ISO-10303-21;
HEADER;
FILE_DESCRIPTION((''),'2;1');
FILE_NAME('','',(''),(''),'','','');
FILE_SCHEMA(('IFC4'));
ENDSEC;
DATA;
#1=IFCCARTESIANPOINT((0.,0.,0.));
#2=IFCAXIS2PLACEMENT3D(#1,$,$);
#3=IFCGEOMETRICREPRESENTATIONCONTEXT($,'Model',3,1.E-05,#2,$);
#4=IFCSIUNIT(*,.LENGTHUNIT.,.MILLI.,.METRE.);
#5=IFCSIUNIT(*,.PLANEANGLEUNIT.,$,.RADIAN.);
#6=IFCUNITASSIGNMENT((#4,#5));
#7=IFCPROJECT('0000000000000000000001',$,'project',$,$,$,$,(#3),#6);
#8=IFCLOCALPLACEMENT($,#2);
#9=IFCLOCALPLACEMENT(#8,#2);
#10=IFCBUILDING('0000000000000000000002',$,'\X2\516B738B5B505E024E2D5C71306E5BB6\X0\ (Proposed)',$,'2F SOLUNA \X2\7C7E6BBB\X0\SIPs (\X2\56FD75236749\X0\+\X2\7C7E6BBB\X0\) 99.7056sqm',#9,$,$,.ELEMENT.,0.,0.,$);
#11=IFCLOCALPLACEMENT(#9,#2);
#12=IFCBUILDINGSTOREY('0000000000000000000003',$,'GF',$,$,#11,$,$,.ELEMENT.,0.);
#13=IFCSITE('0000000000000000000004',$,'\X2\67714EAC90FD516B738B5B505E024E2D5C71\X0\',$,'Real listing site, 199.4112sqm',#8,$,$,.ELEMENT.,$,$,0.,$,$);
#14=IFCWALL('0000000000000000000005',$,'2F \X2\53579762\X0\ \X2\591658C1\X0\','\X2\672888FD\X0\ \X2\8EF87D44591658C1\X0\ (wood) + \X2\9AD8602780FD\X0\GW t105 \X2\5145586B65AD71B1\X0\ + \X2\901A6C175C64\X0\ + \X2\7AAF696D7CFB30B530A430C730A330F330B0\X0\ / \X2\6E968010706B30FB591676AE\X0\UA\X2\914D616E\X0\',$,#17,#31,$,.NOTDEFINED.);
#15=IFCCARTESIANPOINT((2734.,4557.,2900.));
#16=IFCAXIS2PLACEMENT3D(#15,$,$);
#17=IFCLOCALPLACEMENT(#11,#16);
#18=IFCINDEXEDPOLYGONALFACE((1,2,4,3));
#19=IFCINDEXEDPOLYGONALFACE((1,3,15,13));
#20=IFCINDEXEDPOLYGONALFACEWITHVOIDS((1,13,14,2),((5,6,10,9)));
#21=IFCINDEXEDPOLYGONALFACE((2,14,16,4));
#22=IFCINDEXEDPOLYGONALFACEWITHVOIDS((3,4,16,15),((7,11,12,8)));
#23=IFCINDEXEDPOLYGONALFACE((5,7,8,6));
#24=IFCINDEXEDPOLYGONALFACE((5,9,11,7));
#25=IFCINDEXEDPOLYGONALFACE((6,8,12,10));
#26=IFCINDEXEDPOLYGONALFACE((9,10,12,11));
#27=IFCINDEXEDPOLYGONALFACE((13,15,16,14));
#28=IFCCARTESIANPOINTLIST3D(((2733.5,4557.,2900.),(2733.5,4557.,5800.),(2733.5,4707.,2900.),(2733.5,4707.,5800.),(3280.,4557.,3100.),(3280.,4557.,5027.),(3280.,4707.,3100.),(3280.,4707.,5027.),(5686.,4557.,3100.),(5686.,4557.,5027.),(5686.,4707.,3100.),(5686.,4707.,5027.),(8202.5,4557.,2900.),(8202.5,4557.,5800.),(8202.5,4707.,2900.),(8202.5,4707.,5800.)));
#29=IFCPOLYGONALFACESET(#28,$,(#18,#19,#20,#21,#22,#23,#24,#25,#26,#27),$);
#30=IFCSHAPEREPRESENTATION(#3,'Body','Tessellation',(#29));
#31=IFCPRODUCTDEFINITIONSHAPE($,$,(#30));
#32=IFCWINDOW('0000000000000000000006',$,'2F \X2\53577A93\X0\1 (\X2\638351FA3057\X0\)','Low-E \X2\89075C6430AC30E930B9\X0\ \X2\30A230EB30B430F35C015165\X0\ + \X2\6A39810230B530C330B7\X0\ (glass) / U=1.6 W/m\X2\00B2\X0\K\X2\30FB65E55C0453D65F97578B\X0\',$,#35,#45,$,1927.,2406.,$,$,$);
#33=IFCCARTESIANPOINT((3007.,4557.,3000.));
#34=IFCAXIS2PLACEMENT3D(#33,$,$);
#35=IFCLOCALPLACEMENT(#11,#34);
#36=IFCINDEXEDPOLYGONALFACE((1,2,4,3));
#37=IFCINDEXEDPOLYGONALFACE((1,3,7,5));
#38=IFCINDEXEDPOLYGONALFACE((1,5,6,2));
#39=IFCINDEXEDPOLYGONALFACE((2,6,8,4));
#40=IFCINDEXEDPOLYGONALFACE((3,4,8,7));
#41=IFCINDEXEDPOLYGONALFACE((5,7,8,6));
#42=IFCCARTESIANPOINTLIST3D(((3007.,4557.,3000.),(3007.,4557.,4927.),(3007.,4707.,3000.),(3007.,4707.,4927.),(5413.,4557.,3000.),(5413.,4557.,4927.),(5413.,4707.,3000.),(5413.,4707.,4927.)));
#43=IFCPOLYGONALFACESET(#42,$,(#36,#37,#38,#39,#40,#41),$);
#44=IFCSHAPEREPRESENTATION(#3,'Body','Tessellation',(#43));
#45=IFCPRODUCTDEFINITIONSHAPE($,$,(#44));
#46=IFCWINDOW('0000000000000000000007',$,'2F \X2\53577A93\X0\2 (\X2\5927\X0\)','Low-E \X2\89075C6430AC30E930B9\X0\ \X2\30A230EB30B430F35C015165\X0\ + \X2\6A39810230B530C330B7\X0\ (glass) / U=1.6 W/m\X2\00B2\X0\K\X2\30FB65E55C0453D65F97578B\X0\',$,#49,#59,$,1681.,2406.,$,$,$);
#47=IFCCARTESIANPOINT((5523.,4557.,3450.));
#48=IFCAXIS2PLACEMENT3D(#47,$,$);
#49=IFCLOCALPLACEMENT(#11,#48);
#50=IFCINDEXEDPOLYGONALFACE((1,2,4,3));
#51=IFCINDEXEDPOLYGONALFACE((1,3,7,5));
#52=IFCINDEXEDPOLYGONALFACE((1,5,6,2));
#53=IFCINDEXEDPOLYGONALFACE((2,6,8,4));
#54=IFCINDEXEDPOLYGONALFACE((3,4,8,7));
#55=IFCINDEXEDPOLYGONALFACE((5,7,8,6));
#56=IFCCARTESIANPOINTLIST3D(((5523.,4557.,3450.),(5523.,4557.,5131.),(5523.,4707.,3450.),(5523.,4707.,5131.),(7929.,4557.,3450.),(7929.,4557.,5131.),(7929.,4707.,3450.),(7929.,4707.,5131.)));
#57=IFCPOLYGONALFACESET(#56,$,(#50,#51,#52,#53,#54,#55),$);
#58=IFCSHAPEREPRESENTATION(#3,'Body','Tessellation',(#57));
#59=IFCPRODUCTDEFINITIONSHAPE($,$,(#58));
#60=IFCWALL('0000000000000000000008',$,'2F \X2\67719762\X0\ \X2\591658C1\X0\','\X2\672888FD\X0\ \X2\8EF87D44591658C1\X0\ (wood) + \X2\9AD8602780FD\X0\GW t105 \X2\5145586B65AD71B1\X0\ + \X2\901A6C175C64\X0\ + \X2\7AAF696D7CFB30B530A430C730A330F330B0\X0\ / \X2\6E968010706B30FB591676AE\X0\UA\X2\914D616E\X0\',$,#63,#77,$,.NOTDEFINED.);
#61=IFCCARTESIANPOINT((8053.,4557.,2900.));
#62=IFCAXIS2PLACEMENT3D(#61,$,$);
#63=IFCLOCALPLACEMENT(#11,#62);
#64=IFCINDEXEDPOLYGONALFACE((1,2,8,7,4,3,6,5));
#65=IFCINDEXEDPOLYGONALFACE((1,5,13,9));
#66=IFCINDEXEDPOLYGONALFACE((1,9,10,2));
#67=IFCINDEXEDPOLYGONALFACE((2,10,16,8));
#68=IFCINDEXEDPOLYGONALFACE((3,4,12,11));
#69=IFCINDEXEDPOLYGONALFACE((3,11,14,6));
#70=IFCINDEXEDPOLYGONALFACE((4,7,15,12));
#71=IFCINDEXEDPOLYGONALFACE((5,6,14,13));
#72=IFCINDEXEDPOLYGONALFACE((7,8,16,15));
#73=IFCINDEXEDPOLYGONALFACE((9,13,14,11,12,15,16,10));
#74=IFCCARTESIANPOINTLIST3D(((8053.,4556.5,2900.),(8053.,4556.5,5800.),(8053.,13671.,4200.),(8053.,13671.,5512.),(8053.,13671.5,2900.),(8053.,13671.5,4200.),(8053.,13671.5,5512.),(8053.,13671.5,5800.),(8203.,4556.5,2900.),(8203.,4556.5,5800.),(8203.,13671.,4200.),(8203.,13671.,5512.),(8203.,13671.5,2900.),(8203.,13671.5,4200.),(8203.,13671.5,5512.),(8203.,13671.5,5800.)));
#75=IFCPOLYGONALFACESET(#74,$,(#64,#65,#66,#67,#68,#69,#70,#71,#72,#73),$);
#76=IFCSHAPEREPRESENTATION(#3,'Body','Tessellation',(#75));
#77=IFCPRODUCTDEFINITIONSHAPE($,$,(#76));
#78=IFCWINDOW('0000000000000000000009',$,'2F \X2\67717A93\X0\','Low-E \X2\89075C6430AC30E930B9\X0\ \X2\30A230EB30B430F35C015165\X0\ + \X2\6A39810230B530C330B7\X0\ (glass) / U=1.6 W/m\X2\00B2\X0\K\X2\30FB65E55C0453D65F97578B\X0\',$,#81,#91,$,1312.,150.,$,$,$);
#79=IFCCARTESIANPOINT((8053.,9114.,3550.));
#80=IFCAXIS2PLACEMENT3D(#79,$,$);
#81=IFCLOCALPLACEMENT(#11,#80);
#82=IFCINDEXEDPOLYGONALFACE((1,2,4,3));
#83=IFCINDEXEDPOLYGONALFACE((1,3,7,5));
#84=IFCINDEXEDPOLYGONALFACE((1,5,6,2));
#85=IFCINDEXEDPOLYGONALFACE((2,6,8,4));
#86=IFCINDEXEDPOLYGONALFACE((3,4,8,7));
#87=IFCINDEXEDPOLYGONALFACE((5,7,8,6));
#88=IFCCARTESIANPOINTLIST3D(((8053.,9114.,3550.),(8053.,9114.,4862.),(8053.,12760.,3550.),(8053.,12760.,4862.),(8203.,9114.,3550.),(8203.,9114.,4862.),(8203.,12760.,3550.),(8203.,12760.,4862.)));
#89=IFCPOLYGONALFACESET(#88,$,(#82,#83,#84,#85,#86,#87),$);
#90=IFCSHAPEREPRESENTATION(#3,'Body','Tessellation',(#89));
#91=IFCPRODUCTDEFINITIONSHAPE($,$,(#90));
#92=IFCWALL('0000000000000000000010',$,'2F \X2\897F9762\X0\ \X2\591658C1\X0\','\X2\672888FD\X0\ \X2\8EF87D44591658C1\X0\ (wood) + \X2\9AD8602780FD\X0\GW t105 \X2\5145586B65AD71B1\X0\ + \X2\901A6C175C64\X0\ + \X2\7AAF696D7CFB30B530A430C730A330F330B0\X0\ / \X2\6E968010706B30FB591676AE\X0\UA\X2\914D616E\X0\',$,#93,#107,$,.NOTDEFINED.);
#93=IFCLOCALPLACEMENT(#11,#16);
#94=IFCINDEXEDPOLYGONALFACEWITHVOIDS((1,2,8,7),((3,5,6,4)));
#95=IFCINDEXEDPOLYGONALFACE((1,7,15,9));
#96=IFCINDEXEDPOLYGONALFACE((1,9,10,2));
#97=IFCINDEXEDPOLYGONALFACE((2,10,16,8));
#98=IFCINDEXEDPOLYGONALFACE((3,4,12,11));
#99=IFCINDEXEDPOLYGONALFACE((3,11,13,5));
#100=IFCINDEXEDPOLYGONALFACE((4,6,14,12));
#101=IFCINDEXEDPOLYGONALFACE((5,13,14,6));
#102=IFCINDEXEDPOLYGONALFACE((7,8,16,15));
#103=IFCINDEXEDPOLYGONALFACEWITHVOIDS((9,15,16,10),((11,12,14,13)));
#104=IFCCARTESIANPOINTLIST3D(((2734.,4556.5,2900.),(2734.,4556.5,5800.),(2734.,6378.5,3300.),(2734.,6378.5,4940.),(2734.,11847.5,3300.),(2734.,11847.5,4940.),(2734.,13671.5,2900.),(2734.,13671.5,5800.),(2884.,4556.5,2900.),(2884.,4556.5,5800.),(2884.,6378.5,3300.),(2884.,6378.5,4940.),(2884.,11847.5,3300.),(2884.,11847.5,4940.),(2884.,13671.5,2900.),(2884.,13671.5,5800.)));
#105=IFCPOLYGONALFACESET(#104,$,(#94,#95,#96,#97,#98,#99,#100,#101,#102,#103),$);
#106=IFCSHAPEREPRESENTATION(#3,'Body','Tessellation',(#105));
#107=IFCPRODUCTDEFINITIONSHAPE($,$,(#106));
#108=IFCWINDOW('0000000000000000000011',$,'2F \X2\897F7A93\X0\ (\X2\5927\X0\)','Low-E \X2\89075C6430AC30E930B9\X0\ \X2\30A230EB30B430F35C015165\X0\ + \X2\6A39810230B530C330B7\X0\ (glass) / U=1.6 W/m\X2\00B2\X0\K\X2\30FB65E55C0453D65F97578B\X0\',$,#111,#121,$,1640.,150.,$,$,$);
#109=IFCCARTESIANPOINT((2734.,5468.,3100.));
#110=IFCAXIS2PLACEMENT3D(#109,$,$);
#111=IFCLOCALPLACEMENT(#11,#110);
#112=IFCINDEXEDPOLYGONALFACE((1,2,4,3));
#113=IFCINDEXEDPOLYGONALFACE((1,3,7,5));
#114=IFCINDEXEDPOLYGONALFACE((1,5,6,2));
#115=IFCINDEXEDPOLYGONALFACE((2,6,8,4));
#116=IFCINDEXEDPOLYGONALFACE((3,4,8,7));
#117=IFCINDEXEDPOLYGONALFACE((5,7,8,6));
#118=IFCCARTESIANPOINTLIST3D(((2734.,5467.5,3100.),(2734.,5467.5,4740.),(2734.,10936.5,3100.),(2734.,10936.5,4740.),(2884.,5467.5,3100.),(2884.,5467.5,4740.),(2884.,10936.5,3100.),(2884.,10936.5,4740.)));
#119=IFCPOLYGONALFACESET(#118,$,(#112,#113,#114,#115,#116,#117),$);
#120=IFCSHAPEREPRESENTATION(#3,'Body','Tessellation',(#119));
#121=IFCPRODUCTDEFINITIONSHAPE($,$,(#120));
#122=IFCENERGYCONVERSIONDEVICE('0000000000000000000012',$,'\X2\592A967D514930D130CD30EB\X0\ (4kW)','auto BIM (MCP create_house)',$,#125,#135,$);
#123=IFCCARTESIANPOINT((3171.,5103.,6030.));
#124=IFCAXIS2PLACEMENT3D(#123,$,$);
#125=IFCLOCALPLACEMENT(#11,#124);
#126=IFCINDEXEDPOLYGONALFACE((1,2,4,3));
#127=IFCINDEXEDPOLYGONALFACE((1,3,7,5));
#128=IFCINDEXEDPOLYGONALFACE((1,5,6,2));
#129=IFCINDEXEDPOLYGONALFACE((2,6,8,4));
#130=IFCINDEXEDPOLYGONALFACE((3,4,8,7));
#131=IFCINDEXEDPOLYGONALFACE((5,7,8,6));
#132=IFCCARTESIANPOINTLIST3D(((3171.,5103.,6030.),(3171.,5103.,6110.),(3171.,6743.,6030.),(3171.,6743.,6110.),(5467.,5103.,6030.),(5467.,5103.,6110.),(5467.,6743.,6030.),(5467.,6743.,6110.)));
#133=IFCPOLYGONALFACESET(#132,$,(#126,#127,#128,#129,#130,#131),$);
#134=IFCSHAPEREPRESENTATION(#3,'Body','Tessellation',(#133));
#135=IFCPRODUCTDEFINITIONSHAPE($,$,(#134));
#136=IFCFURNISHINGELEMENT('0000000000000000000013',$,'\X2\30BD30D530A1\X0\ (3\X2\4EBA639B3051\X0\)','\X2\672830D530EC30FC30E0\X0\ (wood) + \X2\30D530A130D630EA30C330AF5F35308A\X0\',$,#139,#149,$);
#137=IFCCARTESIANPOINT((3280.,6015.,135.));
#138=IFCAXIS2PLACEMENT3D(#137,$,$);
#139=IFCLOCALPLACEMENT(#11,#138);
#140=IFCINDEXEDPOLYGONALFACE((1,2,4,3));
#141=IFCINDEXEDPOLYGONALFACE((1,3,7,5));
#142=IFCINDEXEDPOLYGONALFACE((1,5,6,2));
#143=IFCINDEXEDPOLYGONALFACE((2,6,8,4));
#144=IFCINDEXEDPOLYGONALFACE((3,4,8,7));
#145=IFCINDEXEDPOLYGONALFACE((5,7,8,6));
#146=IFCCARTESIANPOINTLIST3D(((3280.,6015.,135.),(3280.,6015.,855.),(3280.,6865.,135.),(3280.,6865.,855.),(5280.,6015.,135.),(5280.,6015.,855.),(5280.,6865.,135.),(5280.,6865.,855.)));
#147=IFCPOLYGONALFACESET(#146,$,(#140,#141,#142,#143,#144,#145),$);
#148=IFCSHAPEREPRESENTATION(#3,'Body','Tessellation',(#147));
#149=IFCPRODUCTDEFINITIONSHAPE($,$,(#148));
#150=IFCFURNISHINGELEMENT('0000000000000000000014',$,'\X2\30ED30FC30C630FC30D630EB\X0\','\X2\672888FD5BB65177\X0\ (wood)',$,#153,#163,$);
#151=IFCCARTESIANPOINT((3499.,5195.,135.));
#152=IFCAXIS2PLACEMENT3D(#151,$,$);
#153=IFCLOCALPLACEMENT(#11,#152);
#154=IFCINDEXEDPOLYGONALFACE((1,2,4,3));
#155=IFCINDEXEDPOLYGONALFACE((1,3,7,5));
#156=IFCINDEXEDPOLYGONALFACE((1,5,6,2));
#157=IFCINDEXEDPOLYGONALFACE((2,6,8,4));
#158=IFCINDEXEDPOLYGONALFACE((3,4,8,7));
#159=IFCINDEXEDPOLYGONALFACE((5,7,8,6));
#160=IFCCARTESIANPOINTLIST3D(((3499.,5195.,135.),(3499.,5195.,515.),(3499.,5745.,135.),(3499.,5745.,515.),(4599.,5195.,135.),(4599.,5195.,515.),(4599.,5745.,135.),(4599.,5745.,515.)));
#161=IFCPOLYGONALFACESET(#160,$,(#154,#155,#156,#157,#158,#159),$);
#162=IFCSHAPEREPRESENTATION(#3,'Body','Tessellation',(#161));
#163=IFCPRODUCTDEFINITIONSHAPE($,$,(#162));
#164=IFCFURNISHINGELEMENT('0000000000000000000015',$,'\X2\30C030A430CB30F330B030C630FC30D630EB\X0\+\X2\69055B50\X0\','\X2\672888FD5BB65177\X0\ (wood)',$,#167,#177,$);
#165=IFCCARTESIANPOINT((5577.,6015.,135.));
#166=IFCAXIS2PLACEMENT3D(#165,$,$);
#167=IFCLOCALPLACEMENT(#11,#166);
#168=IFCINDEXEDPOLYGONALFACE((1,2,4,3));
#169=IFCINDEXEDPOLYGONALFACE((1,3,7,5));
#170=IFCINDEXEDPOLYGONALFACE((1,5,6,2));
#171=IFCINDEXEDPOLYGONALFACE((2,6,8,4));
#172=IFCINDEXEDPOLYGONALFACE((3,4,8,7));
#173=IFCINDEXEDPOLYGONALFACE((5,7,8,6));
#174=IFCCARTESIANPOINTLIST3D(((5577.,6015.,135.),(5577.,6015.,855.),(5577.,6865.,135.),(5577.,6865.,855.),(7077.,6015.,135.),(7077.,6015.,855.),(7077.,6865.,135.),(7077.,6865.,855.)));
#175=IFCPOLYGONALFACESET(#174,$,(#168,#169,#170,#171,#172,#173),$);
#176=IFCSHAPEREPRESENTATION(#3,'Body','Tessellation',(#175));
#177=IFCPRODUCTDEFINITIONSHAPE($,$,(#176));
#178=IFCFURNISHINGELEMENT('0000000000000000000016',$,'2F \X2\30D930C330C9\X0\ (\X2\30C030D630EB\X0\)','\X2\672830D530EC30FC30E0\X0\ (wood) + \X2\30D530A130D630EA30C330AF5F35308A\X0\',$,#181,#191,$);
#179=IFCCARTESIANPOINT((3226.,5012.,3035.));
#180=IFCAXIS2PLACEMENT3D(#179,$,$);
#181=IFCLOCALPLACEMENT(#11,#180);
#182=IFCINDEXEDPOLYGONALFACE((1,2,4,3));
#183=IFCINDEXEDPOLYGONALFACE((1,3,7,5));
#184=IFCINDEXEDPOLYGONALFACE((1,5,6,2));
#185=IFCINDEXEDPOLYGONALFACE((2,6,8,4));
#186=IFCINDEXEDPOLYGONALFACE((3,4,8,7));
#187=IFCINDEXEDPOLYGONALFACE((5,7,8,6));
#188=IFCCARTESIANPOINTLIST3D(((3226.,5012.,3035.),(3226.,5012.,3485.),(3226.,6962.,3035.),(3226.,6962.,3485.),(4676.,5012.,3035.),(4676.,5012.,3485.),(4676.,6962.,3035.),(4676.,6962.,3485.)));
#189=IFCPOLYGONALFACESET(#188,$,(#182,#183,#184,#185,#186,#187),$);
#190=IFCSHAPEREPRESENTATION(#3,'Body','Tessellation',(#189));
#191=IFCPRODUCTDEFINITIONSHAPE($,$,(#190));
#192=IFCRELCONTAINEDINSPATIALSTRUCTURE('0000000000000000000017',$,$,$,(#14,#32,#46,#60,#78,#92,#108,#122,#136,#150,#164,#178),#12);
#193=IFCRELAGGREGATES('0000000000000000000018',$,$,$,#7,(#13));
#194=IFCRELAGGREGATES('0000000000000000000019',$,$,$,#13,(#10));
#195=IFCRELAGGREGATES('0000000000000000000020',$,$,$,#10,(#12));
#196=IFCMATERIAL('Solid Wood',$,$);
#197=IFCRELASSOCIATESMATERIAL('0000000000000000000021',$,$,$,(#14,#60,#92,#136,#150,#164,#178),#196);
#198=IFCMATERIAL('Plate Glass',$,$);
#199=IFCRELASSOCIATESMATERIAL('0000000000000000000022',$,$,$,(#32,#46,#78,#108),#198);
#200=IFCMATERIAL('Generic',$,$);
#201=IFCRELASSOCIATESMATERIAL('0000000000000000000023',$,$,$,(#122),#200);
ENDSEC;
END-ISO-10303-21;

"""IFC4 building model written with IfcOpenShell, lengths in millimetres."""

from ifc_helpers import new_model, si_unit, frame, frame_2d, origin, place, context, project, spatial, rectangle, extrude, material, element, fill, save


model = new_model("IFC4")

# Units and contexts
model_context = context("Model", 3, precision=1e-05, world=origin())
ifc_project = project(units=[si_unit("LENGTHUNIT", "METRE", prefix="MILLI"), si_unit("PLANEANGLEUNIT", "RADIAN")], contexts=[model_context])

# Site, building, storey
site_placement = place(None, origin())
site = spatial("IfcSite", under=ifc_project, at=site_placement, Name="東京都八王子市中山", ObjectType="Real listing site, 199.4112sqm", CompositionType="ELEMENT", RefElevation=0.0)
building_placement = place(site_placement, origin())
building = spatial("IfcBuilding", under=site, at=building_placement, Name="八王子市中山の家 (Proposed)", ObjectType="2F SOLUNA 籾殻SIPs (国産杉+籾殻) 99.7056sqm", CompositionType="ELEMENT", ElevationOfRefHeight=0.0, ElevationOfTerrain=0.0)
storey_placement = place(building_placement, origin())
storey = spatial("IfcBuildingStorey", under=building, at=storey_placement, Name="GF", CompositionType="ELEMENT", Elevation=0.0)

# Shared definitions
ifc_material_1 = material(Name="Solid Wood")

# Wall, openings, windows
wall_1_placement = place(storey_placement, frame((2734.0, 4557.0, 2900.0)))
wall_1 = element("IfcWall", 1, at=wall_1_placement, inside=storey, material=ifc_material_1, Name="2F 南面 外壁", Description="木製 軸組外壁 (wood) + 高性能GW t105 充填断熱 + 通気層 + 窯業系サイディング / 準耐火・外皮UA配慮", PredefinedType="NOTDEFINED", context=model_context, shape_type="SweptSolid", body=[
    extrude(rectangle(XDim=5469.0, YDim=150.0, at=frame_2d((2734.0, 75.0))), frame((2734.0, 4557.0, 2900.0)), (0.0, 0.0, 1.0), 2900.0),
])
opening_1_placement = place(storey_placement, frame((3007.0, 4557.0, 3000.0)))
opening_1 = element("IfcOpeningElement", 2, at=opening_1_placement, cuts=wall_1, PredefinedType="NOTDEFINED", context=model_context, shape_type="SweptSolid", body=[
    extrude(rectangle(XDim=2406.0, YDim=150.0, at=frame_2d((1203.0, 75.0))), frame((3007.0, 4557.0, 3000.0)), (0.0, 0.0, 1.0), 1927.0),
])
opening_2_placement = place(storey_placement, frame((5523.0, 4557.0, 3450.0)))
opening_2 = element("IfcOpeningElement", 3, at=opening_2_placement, cuts=wall_1, PredefinedType="NOTDEFINED", context=model_context, shape_type="SweptSolid", body=[
    extrude(rectangle(XDim=2406.0, YDim=150.0, at=frame_2d((1203.0, 75.0))), frame((5523.0, 4557.0, 3450.0)), (0.0, 0.0, 1.0), 1681.0),
])
ifc_material_2 = material(Name="Plate Glass")
window_1_placement = place(storey_placement, frame((3007.0, 4557.0, 3000.0)))
window_1 = element("IfcWindow", 4, at=window_1_placement, inside=storey, material=ifc_material_2, Name="2F 南窓1 (掃出し)", Description="Low-E 複層ガラス アルゴン封入 + 樹脂サッシ (glass) / U=1.6 W/m²K・日射取得型", OverallHeight=1927.0, OverallWidth=2406.0, context=model_context, shape_type="SweptSolid", body=[
    extrude(rectangle(XDim=2406.0, YDim=150.0, at=frame_2d((1203.0, 75.0))), frame((3007.0, 4557.0, 3000.0)), (0.0, 0.0, 1.0), 1927.0),
])
fill(opening_1, window_1)
window_2_placement = place(storey_placement, frame((5523.0, 4557.0, 3450.0)))
window_2 = element("IfcWindow", 5, at=window_2_placement, inside=storey, material=ifc_material_2, Name="2F 南窓2 (大)", Description="Low-E 複層ガラス アルゴン封入 + 樹脂サッシ (glass) / U=1.6 W/m²K・日射取得型", OverallHeight=1681.0, OverallWidth=2406.0, context=model_context, shape_type="SweptSolid", body=[
    extrude(rectangle(XDim=2406.0, YDim=150.0, at=frame_2d((1203.0, 75.0))), frame((5523.0, 4557.0, 3450.0)), (0.0, 0.0, 1.0), 1681.0),
])
fill(opening_2, window_2)

# Walls, openings, windows
wall_2_placement = place(storey_placement, frame((8053.0, 4557.0, 2900.0)))
wall_2 = element("IfcWall", 6, at=wall_2_placement, inside=storey, material=ifc_material_1, Name="2F 東面 外壁", Description="木製 軸組外壁 (wood) + 高性能GW t105 充填断熱 + 通気層 + 窯業系サイディング / 準耐火・外皮UA配慮", PredefinedType="NOTDEFINED", context=model_context, shape_type="SweptSolid", body=[
    extrude(rectangle(XDim=150.0, YDim=9115.0, at=frame_2d((75.0, 4557.0))), frame((8053.0, 4557.0, 2900.0)), (0.0, 0.0, 1.0), 2900.0),
])
opening_3_placement = place(storey_placement, frame((8053.0, 9114.0, 3550.0)))
opening_3 = element("IfcOpeningElement", 7, at=opening_3_placement, cuts=wall_2, PredefinedType="NOTDEFINED", context=model_context, shape_type="SweptSolid", body=[
    extrude(rectangle(XDim=150.0, YDim=3646.0, at=frame_2d((75.0, 1823.0))), frame((8053.0, 9114.0, 3550.0)), (0.0, 0.0, 1.0), 1312.0),
])
window_3_placement = place(storey_placement, frame((8053.0, 9114.0, 3550.0)))
window_3 = element("IfcWindow", 8, at=window_3_placement, inside=storey, material=ifc_material_2, Name="2F 東窓", Description="Low-E 複層ガラス アルゴン封入 + 樹脂サッシ (glass) / U=1.6 W/m²K・日射取得型", OverallHeight=1312.0, OverallWidth=150.0, context=model_context, shape_type="SweptSolid", body=[
    extrude(rectangle(XDim=150.0, YDim=3646.0, at=frame_2d((75.0, 1823.0))), frame((8053.0, 9114.0, 3550.0)), (0.0, 0.0, 1.0), 1312.0),
])
fill(opening_3, window_3)
wall_3_placement = place(storey_placement, frame((2734.0, 4557.0, 2900.0)))
wall_3 = element("IfcWall", 9, at=wall_3_placement, inside=storey, material=ifc_material_1, Name="2F 西面 外壁", Description="木製 軸組外壁 (wood) + 高性能GW t105 充填断熱 + 通気層 + 窯業系サイディング / 準耐火・外皮UA配慮", PredefinedType="NOTDEFINED", context=model_context, shape_type="SweptSolid", body=[
    extrude(rectangle(XDim=150.0, YDim=9115.0, at=frame_2d((75.0, 4557.0))), frame((2734.0, 4557.0, 2900.0)), (0.0, 0.0, 1.0), 2900.0),
])
opening_4_placement = place(storey_placement, frame((2734.0, 5468.0, 3100.0)))
opening_4 = element("IfcOpeningElement", 10, at=opening_4_placement, cuts=wall_3, PredefinedType="NOTDEFINED", context=model_context, shape_type="SweptSolid", body=[
    extrude(rectangle(XDim=150.0, YDim=5469.0, at=frame_2d((75.0, 2734.0))), frame((2734.0, 5468.0, 3100.0)), (0.0, 0.0, 1.0), 1640.0),
])
window_4_placement = place(storey_placement, frame((2734.0, 5468.0, 3100.0)))
window_4 = element("IfcWindow", 11, at=window_4_placement, inside=storey, material=ifc_material_2, Name="2F 西窓 (大)", Description="Low-E 複層ガラス アルゴン封入 + 樹脂サッシ (glass) / U=1.6 W/m²K・日射取得型", OverallHeight=1640.0, OverallWidth=150.0, context=model_context, shape_type="SweptSolid", body=[
    extrude(rectangle(XDim=150.0, YDim=5469.0, at=frame_2d((75.0, 2734.0))), frame((2734.0, 5468.0, 3100.0)), (0.0, 0.0, 1.0), 1640.0),
])
fill(opening_4, window_4)

# Shared definitions
ifc_material_3 = material(Name="Generic")

# Energy conversion device
energy_conversion_device_placement = place(storey_placement, frame((3171.0, 5103.0, 6030.0)))
element("IfcEnergyConversionDevice", 12, at=energy_conversion_device_placement, inside=storey, material=ifc_material_3, Name="太陽光パネル (4kW)", Description="auto BIM (MCP create_house)", context=model_context, shape_type="SweptSolid", body=[
    extrude(rectangle(XDim=2296.0, YDim=1640.0, at=frame_2d((1148.0, 820.0))), frame((3171.0, 5103.0, 6030.0)), (0.0, 0.0, 1.0), 80.0),
])

# Furnishing elements
furnishing_1_placement = place(storey_placement, frame((3280.0, 6015.0, 135.0)))
element("IfcFurnishingElement", 13, at=furnishing_1_placement, inside=storey, material=ifc_material_1, Name="ソファ (3人掛け)", Description="木フレーム (wood) + ファブリック張り", context=model_context, shape_type="SweptSolid", body=[
    extrude(rectangle(XDim=2000.0, YDim=850.0, at=frame_2d((1000.0, 425.0))), frame((3280.0, 6015.0, 135.0)), (0.0, 0.0, 1.0), 720.0),
])
furnishing_2_placement = place(storey_placement, frame((3499.0, 5195.0, 135.0)))
element("IfcFurnishingElement", 14, at=furnishing_2_placement, inside=storey, material=ifc_material_1, Name="ローテーブル", Description="木製家具 (wood)", context=model_context, shape_type="SweptSolid", body=[
    extrude(rectangle(XDim=1100.0, YDim=550.0, at=frame_2d((550.0, 275.0))), frame((3499.0, 5195.0, 135.0)), (0.0, 0.0, 1.0), 380.0),
])
furnishing_3_placement = place(storey_placement, frame((5577.0, 6015.0, 135.0)))
element("IfcFurnishingElement", 15, at=furnishing_3_placement, inside=storey, material=ifc_material_1, Name="ダイニングテーブル+椅子", Description="木製家具 (wood)", context=model_context, shape_type="SweptSolid", body=[
    extrude(rectangle(XDim=1500.0, YDim=850.0, at=frame_2d((750.0, 425.0))), frame((5577.0, 6015.0, 135.0)), (0.0, 0.0, 1.0), 720.0),
])
furnishing_4_placement = place(storey_placement, frame((3226.0, 5012.0, 3035.0)))
element("IfcFurnishingElement", 16, at=furnishing_4_placement, inside=storey, material=ifc_material_1, Name="2F ベッド (ダブル)", Description="木フレーム (wood) + ファブリック張り", context=model_context, shape_type="SweptSolid", body=[
    extrude(rectangle(XDim=1450.0, YDim=1950.0, at=frame_2d((725.0, 975.0))), frame((3226.0, 5012.0, 3035.0)), (0.0, 0.0, 1.0), 450.0),
])

save(model, "model.ifc")
